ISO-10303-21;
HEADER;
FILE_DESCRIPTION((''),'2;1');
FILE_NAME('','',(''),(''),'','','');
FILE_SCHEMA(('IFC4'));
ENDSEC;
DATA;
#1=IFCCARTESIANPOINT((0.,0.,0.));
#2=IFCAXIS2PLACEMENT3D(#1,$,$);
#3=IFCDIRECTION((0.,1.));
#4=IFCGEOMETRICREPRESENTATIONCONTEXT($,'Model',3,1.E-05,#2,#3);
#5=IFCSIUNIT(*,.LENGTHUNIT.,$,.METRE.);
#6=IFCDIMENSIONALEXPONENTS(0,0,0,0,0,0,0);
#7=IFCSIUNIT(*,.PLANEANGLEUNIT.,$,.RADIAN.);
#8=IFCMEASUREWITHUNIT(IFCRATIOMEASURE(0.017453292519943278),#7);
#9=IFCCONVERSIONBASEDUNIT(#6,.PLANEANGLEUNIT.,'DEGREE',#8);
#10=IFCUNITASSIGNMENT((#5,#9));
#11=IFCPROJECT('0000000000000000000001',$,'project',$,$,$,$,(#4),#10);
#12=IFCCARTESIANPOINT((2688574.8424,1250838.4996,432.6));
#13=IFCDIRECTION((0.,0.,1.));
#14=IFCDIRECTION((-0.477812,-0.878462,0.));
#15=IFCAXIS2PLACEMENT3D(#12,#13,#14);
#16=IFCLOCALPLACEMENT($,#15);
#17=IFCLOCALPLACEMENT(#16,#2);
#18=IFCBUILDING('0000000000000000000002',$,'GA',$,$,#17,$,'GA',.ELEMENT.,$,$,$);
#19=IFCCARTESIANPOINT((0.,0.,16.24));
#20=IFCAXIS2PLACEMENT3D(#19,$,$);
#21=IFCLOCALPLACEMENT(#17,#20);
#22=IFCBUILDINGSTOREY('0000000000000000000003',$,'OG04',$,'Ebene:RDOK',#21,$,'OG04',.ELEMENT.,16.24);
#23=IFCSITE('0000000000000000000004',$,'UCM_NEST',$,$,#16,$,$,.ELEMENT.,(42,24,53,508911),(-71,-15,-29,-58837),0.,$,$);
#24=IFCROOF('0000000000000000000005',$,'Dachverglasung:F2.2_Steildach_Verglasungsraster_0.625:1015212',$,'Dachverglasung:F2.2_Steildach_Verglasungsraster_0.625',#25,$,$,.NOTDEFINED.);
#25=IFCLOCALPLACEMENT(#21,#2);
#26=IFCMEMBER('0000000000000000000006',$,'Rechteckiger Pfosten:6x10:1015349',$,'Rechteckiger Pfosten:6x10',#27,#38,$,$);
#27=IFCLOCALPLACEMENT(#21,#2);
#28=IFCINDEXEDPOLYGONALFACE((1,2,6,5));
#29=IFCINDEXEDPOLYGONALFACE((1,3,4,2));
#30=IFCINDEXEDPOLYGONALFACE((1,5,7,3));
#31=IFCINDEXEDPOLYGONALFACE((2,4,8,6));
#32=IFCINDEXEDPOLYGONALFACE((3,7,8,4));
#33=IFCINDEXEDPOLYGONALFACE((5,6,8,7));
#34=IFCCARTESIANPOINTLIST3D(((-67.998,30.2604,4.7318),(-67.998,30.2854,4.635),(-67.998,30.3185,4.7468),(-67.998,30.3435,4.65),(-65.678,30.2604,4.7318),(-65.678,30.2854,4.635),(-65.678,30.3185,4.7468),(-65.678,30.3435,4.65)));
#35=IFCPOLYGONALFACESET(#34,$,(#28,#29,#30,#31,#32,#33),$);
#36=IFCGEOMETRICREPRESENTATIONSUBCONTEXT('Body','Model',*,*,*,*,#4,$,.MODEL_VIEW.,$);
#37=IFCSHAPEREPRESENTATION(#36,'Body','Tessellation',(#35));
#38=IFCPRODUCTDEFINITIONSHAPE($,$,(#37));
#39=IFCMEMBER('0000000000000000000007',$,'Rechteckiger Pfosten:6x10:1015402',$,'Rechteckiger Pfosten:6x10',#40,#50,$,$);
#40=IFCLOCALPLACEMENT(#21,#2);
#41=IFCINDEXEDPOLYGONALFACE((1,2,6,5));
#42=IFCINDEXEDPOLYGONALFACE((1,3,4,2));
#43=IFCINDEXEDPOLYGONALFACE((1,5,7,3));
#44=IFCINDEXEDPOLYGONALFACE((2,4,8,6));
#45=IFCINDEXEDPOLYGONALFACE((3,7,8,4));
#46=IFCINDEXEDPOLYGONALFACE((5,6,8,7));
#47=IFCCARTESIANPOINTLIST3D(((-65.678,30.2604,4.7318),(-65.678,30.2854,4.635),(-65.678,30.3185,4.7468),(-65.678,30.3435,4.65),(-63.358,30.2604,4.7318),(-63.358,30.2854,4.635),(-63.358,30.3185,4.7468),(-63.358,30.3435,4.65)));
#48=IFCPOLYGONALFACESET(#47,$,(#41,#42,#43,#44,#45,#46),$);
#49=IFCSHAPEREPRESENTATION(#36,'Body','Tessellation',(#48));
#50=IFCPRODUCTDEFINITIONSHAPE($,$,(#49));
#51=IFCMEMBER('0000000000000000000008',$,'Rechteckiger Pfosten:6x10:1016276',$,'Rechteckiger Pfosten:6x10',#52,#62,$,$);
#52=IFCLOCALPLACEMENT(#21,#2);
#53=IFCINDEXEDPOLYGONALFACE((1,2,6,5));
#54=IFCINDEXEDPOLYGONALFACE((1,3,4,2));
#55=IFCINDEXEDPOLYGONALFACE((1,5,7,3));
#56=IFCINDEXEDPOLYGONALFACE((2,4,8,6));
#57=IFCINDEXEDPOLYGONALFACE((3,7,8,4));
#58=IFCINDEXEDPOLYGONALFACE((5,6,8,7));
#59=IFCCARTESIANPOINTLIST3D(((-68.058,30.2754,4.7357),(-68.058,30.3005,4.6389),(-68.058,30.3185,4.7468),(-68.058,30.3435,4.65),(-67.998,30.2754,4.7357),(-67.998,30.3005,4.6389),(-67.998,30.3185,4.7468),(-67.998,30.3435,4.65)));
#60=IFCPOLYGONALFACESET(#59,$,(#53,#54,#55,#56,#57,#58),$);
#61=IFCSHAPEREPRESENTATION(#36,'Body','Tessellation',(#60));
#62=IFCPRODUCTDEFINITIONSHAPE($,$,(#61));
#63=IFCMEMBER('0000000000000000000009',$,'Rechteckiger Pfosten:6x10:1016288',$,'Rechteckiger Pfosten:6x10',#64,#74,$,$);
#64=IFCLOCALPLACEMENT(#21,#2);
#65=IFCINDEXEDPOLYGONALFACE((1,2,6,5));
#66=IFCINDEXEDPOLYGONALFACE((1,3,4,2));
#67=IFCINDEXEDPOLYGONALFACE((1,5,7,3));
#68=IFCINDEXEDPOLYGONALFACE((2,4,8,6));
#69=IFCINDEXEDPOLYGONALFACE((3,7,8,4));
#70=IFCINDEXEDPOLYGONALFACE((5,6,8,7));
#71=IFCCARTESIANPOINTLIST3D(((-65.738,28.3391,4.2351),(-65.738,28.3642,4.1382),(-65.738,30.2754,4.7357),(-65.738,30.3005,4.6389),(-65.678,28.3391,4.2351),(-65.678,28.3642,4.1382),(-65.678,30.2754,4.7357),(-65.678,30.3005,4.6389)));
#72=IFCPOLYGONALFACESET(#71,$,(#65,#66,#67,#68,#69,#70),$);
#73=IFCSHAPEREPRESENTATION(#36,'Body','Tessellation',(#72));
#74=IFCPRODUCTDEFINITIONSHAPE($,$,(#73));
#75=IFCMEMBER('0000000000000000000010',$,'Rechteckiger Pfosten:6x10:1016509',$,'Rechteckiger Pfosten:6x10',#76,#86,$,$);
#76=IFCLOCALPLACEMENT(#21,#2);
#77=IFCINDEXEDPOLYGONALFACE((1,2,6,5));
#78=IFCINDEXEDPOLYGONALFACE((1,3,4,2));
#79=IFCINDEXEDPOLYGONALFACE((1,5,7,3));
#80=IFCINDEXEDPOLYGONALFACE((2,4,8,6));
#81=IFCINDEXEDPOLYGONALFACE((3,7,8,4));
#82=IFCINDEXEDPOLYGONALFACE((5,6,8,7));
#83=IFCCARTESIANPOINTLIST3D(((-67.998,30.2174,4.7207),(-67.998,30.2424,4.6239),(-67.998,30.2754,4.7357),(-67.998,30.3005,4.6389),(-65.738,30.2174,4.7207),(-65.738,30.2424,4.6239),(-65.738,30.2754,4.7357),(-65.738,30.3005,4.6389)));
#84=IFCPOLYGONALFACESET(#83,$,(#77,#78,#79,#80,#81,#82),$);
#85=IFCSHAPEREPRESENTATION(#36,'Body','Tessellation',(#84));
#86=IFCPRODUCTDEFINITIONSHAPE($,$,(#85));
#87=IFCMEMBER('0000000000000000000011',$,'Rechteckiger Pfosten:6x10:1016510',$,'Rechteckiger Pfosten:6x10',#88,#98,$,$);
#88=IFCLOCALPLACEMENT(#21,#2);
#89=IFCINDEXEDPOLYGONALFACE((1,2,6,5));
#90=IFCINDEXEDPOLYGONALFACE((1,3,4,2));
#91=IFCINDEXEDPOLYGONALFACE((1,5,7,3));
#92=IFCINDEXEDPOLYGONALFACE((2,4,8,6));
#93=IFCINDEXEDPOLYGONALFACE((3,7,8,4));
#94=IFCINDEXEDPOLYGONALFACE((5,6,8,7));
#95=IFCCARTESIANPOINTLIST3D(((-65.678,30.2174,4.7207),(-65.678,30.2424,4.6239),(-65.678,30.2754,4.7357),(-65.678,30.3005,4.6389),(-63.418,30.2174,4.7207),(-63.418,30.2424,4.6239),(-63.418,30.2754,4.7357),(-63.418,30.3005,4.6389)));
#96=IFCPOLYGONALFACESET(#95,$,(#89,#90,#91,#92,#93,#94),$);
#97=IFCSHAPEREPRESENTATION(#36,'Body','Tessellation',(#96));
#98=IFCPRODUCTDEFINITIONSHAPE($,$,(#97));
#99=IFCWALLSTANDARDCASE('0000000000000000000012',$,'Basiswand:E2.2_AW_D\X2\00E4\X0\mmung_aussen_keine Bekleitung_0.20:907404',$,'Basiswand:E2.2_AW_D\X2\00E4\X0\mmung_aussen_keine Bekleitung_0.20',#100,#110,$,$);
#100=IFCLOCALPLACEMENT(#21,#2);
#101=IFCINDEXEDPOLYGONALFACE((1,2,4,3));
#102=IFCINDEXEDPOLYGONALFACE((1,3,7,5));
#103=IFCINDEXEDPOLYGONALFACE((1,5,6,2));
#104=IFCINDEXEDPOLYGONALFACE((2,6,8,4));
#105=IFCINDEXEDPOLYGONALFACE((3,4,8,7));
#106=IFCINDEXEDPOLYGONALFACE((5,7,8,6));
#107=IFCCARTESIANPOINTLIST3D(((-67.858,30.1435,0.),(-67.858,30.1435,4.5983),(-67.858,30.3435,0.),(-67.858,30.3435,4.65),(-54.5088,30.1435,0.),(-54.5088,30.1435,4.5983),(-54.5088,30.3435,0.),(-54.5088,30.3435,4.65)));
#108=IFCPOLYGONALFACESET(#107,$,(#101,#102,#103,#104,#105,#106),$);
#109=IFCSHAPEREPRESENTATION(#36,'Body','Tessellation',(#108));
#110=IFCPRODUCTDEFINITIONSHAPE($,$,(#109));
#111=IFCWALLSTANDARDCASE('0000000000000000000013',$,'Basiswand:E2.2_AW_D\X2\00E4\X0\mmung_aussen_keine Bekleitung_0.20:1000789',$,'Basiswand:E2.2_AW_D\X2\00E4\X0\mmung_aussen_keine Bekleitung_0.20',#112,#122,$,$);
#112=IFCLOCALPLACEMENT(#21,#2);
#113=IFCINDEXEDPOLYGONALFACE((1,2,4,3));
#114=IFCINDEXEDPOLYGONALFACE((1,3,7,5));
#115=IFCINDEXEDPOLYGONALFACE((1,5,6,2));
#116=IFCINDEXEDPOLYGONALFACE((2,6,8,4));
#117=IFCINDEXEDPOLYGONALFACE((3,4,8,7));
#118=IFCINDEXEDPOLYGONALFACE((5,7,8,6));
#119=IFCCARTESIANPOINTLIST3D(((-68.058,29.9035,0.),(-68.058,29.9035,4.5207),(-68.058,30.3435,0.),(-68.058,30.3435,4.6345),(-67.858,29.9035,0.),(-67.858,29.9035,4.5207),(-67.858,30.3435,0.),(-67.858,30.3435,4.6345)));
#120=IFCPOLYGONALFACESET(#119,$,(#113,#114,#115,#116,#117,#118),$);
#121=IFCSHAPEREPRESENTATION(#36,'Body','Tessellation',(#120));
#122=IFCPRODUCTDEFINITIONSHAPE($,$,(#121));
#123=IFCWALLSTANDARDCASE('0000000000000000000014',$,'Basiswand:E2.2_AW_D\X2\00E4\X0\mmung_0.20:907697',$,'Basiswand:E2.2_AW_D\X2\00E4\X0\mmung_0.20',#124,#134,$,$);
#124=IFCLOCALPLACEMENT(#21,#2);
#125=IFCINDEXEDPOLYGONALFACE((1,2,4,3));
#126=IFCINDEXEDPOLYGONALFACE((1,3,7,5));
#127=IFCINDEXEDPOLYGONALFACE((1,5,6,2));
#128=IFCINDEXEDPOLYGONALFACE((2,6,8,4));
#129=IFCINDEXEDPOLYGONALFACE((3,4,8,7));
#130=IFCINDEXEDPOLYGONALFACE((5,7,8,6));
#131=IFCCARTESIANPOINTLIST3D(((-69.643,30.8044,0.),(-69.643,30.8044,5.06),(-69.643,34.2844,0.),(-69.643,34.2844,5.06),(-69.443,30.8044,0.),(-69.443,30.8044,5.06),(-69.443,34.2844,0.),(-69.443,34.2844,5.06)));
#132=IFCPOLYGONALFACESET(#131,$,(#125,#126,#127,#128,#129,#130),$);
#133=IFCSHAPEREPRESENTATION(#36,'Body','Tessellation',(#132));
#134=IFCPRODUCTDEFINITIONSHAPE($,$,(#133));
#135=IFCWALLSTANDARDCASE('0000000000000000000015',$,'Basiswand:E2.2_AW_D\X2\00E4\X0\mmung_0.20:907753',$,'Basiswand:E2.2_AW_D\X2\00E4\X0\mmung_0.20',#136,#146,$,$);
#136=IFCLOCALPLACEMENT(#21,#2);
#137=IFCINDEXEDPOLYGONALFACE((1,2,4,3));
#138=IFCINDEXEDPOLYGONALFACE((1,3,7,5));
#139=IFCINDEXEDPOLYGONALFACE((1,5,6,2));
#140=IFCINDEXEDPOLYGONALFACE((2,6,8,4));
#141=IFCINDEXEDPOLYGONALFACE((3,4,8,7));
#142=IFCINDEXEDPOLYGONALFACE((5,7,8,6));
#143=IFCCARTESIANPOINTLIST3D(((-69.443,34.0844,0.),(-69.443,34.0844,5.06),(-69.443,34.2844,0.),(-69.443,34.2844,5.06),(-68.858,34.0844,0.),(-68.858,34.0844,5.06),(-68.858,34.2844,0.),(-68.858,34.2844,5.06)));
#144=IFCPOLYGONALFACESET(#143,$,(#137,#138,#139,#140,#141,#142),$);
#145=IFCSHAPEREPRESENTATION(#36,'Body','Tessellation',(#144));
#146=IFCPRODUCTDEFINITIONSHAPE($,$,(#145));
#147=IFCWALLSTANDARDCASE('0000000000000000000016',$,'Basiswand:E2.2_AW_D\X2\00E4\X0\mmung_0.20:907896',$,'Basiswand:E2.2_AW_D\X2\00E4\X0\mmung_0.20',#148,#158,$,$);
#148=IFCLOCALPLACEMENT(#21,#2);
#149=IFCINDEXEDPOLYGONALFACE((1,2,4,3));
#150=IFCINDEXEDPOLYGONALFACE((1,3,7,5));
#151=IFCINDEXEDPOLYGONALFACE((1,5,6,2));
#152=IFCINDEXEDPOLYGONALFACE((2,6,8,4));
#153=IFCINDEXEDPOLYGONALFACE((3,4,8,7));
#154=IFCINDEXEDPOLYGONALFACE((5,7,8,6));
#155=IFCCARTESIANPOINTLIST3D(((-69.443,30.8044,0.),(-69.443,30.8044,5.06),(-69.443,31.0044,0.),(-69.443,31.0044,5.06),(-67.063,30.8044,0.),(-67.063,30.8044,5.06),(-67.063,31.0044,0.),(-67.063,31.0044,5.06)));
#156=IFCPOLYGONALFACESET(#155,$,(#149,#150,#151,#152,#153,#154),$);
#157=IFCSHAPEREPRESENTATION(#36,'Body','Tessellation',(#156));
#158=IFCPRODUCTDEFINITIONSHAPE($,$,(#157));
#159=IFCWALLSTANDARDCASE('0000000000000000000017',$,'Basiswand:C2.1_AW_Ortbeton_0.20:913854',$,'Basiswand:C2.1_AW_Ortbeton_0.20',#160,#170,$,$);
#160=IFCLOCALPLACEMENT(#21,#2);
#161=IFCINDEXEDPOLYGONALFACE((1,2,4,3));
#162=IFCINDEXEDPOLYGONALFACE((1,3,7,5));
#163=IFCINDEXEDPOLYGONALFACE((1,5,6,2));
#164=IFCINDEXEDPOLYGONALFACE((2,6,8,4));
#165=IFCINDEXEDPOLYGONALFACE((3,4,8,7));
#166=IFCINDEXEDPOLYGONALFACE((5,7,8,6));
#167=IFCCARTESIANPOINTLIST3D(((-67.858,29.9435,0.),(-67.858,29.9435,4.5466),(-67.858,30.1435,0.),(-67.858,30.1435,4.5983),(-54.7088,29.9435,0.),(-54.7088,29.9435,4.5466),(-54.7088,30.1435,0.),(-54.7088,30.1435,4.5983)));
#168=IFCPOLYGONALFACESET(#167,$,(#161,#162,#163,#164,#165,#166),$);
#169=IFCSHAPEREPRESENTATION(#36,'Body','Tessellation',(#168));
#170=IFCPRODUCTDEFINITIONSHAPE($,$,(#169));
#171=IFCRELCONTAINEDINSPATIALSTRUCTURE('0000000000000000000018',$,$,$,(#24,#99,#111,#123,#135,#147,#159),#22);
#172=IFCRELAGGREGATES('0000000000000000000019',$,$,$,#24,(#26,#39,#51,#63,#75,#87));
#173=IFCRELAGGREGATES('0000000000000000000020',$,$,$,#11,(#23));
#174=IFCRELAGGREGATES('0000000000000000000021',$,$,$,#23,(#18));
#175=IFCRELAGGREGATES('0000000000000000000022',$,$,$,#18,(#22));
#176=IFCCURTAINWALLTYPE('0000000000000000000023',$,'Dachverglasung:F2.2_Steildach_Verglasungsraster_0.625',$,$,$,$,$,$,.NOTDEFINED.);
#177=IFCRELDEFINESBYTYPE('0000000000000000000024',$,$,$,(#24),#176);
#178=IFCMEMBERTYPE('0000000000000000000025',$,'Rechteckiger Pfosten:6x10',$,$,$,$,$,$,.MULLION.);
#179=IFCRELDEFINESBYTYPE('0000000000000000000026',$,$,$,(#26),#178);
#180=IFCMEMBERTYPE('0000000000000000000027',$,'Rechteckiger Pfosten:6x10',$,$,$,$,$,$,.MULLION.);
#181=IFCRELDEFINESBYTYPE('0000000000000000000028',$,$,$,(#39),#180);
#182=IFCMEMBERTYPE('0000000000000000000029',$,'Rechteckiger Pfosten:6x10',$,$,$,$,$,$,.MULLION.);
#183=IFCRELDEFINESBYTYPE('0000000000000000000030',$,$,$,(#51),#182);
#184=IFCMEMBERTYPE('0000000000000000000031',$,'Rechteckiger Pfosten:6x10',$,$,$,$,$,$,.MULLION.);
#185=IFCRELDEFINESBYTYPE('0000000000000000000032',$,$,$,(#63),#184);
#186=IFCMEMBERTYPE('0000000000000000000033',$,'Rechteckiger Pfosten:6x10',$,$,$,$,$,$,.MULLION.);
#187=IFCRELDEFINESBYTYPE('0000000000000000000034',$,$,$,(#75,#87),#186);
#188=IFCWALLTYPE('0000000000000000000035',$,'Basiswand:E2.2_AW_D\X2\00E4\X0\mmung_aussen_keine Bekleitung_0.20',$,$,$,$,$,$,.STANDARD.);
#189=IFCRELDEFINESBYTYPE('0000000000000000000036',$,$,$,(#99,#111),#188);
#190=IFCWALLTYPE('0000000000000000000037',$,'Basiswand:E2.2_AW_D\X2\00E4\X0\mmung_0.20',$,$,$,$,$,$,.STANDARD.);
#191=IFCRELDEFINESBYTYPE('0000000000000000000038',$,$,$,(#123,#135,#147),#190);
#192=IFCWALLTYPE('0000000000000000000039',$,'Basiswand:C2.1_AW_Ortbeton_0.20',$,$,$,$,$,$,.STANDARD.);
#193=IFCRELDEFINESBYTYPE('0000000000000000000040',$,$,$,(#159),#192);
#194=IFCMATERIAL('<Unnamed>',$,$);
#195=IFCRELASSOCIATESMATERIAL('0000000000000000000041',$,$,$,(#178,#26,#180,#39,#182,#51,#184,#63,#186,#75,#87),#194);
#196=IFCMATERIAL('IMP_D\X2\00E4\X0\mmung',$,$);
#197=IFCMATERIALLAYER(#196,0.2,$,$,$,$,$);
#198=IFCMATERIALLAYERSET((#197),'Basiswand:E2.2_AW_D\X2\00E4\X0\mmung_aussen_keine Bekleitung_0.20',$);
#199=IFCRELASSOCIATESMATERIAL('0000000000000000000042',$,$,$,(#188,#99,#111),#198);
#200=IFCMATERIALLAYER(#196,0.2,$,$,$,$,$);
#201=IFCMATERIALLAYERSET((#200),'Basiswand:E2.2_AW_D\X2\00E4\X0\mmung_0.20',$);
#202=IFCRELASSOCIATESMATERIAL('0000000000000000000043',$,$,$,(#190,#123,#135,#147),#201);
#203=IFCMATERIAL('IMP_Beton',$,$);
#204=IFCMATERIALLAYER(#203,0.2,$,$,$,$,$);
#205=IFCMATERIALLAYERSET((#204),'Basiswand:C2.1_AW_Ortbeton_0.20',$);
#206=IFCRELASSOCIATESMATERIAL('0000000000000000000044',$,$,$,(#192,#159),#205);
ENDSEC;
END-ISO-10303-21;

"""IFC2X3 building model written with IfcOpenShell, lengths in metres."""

from ifc_helpers import new_model, entity, si_unit, converted_unit, direction, frame, frame_2d, origin, origin_2d_with_axis, place, context, subcontext, project, spatial, polyline, rectangle, extrude, clip, halfspace, bounded_halfspace, source, transform, mapped, material, layer, layer_set, layer_usage, type_object, type_shapes, element, aggregate, save


model = new_model("IFC2X3")

# Units and contexts
model_context = context("Model", 3, precision=1e-05, world=origin(), true_north=direction((0.0, 1.0)))
body_context = subcontext(model_context, "Body", "Model", "MODEL_VIEW")
ifc_project = project(units=[si_unit("LENGTHUNIT", "METRE"), converted_unit("PLANEANGLEUNIT", "DEGREE", entity("IfcRatioMeasure", 0.017453292519943278), si_unit("PLANEANGLEUNIT", "RADIAN"), dimensions=[0, 0, 0, 0, 0, 0, 0])], contexts=[model_context])

# Site, building, storey
site_placement = place(None, frame((2688574.8424, 1250838.4996, 432.6), z_axis=(0.0, 0.0, 1.0), x_axis=(-0.477812, -0.878462, 0.0)))
site = spatial("IfcSite", under=ifc_project, at=site_placement, Name="UCM_NEST", CompositionType="ELEMENT", RefLatitude=(42, 24, 53, 508911), RefLongitude=(-71, -15, -29, -58837), RefElevation=0.0)
building_placement = place(site_placement, origin())
building = spatial("IfcBuilding", under=site, at=building_placement, Name="GA", LongName="GA", CompositionType="ELEMENT")
storey_placement = place(building_placement, frame((0.0, 0.0, 16.24)))
storey = spatial("IfcBuildingStorey", under=building, at=storey_placement, Name="OG04", ObjectType="Ebene:RDOK", LongName="OG04", CompositionType="ELEMENT", Elevation=16.24)

# Roof, members
curtain_wall_type = type_object("IfcCurtainWallType", Name="Dachverglasung:F2.2_Steildach_Verglasungsraster_0.625", PredefinedType="NOTDEFINED")
roof_placement = place(storey_placement, frame((0.0, 0.0, -16.24)))
roof = element("IfcRoof", 1, at=roof_placement, inside=storey, type_object=curtain_wall_type, Name="Dachverglasung:F2.2_Steildach_Verglasungsraster_0.625:1015212", ObjectType="Dachverglasung:F2.2_Steildach_Verglasungsraster_0.625", ShapeType="NOTDEFINED")
ifc_material_1 = material(Name="<Unnamed>")
member_type_1 = type_object("IfcMemberType", Name="Rechteckiger Pfosten:6x10", PredefinedType="MULLION", material=ifc_material_1)
shared_shape_1 = source(origin(), body_context, "Body", "SweptSolid", [
    extrude(rectangle(XDim=0.1, YDim=0.06, at=origin_2d_with_axis()), frame((-0.03, -0.05, -2.32), z_axis=(0.0, 0.0, 1.0), x_axis=(0.0, -1.0, 0.0)), (0.0, 0.0, 1.0), 2.32),
])
type_shapes(member_type_1, [shared_shape_1])
member_1_placement = place(roof_placement, frame((-67.998, 30.3435, 20.89), z_axis=(-1.0, 0.0, 0.0), x_axis=(0.0, 0.968163, 0.250322)))
member_1 = element("IfcMember", 2, at=member_1_placement, type_object=member_type_1, material=ifc_material_1, Name="Rechteckiger Pfosten:6x10:1015349", ObjectType="Rechteckiger Pfosten:6x10", context=body_context, shape_type="MappedRepresentation", body=[
    mapped(shared_shape_1, transform((0.0, 0.0, 0.0), scale=1.0)),
])
member_type_2 = type_object("IfcMemberType", Name="Rechteckiger Pfosten:6x10", PredefinedType="MULLION", material=ifc_material_1)
shared_shape_2 = source(origin(), body_context, "Body", "SweptSolid", [
    extrude(rectangle(XDim=0.1, YDim=0.06, at=origin_2d_with_axis()), frame((-0.03, -0.05, -2.32), z_axis=(0.0, 0.0, 1.0), x_axis=(0.0, -1.0, 0.0)), (0.0, 0.0, 1.0), 2.32),
])
type_shapes(member_type_2, [shared_shape_2])
member_2_placement = place(roof_placement, frame((-65.678, 30.3435, 20.89), z_axis=(-1.0, 0.0, 0.0), x_axis=(0.0, 0.968163, 0.250322)))
member_2 = element("IfcMember", 3, at=member_2_placement, type_object=member_type_2, material=ifc_material_1, Name="Rechteckiger Pfosten:6x10:1015402", ObjectType="Rechteckiger Pfosten:6x10", context=body_context, shape_type="MappedRepresentation", body=[
    mapped(shared_shape_2, transform((0.0, 0.0, 0.0), scale=1.0)),
])
member_type_3 = type_object("IfcMemberType", Name="Rechteckiger Pfosten:6x10", PredefinedType="MULLION", material=ifc_material_1)
shared_shape_3 = source(origin(), body_context, "Body", "SweptSolid", [
    extrude(rectangle(XDim=0.1, YDim=0.06, at=origin_2d_with_axis()), frame((-0.03, -0.05, -0.0444), z_axis=(0.0, 0.0, 1.0), x_axis=(0.0, -1.0, 0.0)), (0.0, 0.0, 1.0), 0.0444),
])
type_shapes(member_type_3, [shared_shape_3])
member_3_placement = place(roof_placement, frame((-68.058, 30.3005, 20.8789), z_axis=(0.0, -0.968163, -0.250322), x_axis=(-1.0, 0.0, 0.0)))
member_3 = element("IfcMember", 4, at=member_3_placement, type_object=member_type_3, material=ifc_material_1, Name="Rechteckiger Pfosten:6x10:1016276", ObjectType="Rechteckiger Pfosten:6x10", context=body_context, shape_type="MappedRepresentation", body=[
    mapped(shared_shape_3, transform((0.0, 0.0, 0.0), scale=1.0)),
])
member_type_4 = type_object("IfcMemberType", Name="Rechteckiger Pfosten:6x10", PredefinedType="MULLION", material=ifc_material_1)
shared_shape_4 = source(origin(), body_context, "Body", "SweptSolid", [
    extrude(rectangle(XDim=0.1, YDim=0.06, at=origin_2d_with_axis()), frame((-0.03, -0.05, -2.0), z_axis=(0.0, 0.0, 1.0), x_axis=(0.0, -1.0, 0.0)), (0.0, 0.0, 1.0), 2.0),
])
type_shapes(member_type_4, [shared_shape_4])
member_4_placement = place(roof_placement, frame((-65.678, 30.3005, 20.8789), z_axis=(0.0, 0.968163, 0.250322), x_axis=(1.0, 0.0, 0.0)))
member_4 = element("IfcMember", 5, at=member_4_placement, type_object=member_type_4, material=ifc_material_1, Name="Rechteckiger Pfosten:6x10:1016288", ObjectType="Rechteckiger Pfosten:6x10", context=body_context, shape_type="MappedRepresentation", body=[
    mapped(shared_shape_4, transform((0.0, 0.0, 0.0), scale=1.0)),
])
member_type_5 = type_object("IfcMemberType", Name="Rechteckiger Pfosten:6x10", PredefinedType="MULLION", material=ifc_material_1)
shared_shape_5 = source(origin(), body_context, "Body", "SweptSolid", [
    extrude(rectangle(XDim=0.1, YDim=0.06, at=origin_2d_with_axis()), frame((-0.03, -0.05, -2.26), z_axis=(0.0, 0.0, 1.0), x_axis=(0.0, -1.0, 0.0)), (0.0, 0.0, 1.0), 2.26),
])
type_shapes(member_type_5, [shared_shape_5])
member_5_placement = place(roof_placement, frame((-67.998, 30.3005, 20.8789), z_axis=(-1.0, 0.0, 0.0), x_axis=(0.0, 0.968163, 0.250322)))
member_5 = element("IfcMember", 6, at=member_5_placement, type_object=member_type_5, material=ifc_material_1, Name="Rechteckiger Pfosten:6x10:1016509", ObjectType="Rechteckiger Pfosten:6x10", context=body_context, shape_type="MappedRepresentation", body=[
    mapped(shared_shape_5, transform((0.0, 0.0, 0.0), scale=1.0)),
])
member_6_placement = place(roof_placement, frame((-65.678, 30.3005, 20.8789), z_axis=(-1.0, 0.0, 0.0), x_axis=(0.0, 0.968163, 0.250322)))
member_6 = element("IfcMember", 7, at=member_6_placement, type_object=member_type_5, material=ifc_material_1, Name="Rechteckiger Pfosten:6x10:1016510", ObjectType="Rechteckiger Pfosten:6x10", context=body_context, shape_type="MappedRepresentation", body=[
    mapped(shared_shape_5, transform((0.0, 0.0, 0.0), scale=1.0)),
])
aggregate(roof, [member_1, member_2, member_3, member_4, member_5, member_6])

# Walls
ifc_material_2 = material(Name="IMP_Dämmung")
ifc_layer_1 = layer(ifc_material_2, 0.2)
ifc_layer_set_1 = layer_set([ifc_layer_1], Name="Basiswand:E2.2_AW_Dämmung_aussen_keine Bekleitung_0.20")
ifc_layer_usage_1 = layer_usage(ifc_layer_set_1, "AXIS2", "NEGATIVE", 0.1)
wall_type_1 = type_object("IfcWallType", Name="Basiswand:E2.2_AW_Dämmung_aussen_keine Bekleitung_0.20", PredefinedType="STANDARD", material=ifc_layer_set_1)
wall_1_placement = place(storey_placement, frame((-67.858, 30.2435, 0.0)))
element("IfcWallStandardCase", 8, at=wall_1_placement, inside=storey, type_object=wall_type_1, material=ifc_layer_usage_1, Name="Basiswand:E2.2_AW_Dämmung_aussen_keine Bekleitung_0.20:907404", ObjectType="Basiswand:E2.2_AW_Dämmung_aussen_keine Bekleitung_0.20", context=body_context, shape_type="Clipping", body=[
    clip(extrude(rectangle(XDim=13.3492, YDim=0.2, at=frame_2d((6.6746, 0.0), x_axis=(-1.0, 0.0))), origin(), (0.0, 0.0, 1.0), 4.65), bounded_halfspace(frame((0.0, -0.1, 4.5983), z_axis=(0.0, -0.250322, 0.968163), x_axis=(1.0, 0.0, 0.0)), False, frame((0.0, -0.1, 4.5983)), polyline([(0.0, 0.0), (13.3492, 0.0), (13.3492, 0.2), (0.0, 0.2), (0.0, 0.0)]))),
])
wall_2_placement = place(storey_placement, frame((-67.958, 30.3435, 0.0), z_axis=(0.0, 0.0, 1.0), x_axis=(0.0, -1.0, 0.0)))
element("IfcWallStandardCase", 9, at=wall_2_placement, inside=storey, type_object=wall_type_1, material=ifc_layer_usage_1, Name="Basiswand:E2.2_AW_Dämmung_aussen_keine Bekleitung_0.20:1000789", ObjectType="Basiswand:E2.2_AW_Dämmung_aussen_keine Bekleitung_0.20", context=body_context, shape_type="Clipping", body=[
    clip(extrude(rectangle(XDim=0.44, YDim=0.2, at=frame_2d((0.22, 0.0), x_axis=(-1.0, 0.0))), origin(), (0.0, 0.0, 1.0), 4.6345), halfspace(frame((0.0, -0.1, 4.6345), z_axis=(0.250322, 0.0, 0.968163), x_axis=(0.0, 1.0, 0.0)), False)),
])
ifc_layer_2 = layer(ifc_material_2, 0.2)
ifc_layer_set_2 = layer_set([ifc_layer_2], Name="Basiswand:E2.2_AW_Dämmung_0.20")
ifc_layer_usage_2 = layer_usage(ifc_layer_set_2, "AXIS2", "NEGATIVE", 0.1)
wall_type_2 = type_object("IfcWallType", Name="Basiswand:E2.2_AW_Dämmung_0.20", PredefinedType="STANDARD", material=ifc_layer_set_2)
wall_3_placement = place(storey_placement, frame((-69.543, 30.8044, 0.0), z_axis=(0.0, 0.0, 1.0), x_axis=(0.0, 1.0, 0.0)))
element("IfcWallStandardCase", 10, at=wall_3_placement, inside=storey, type_object=wall_type_2, material=ifc_layer_usage_2, Name="Basiswand:E2.2_AW_Dämmung_0.20:907697", ObjectType="Basiswand:E2.2_AW_Dämmung_0.20", context=body_context, shape_type="SweptSolid", body=[
    extrude(rectangle(XDim=3.48, YDim=0.2, at=frame_2d((1.74, 0.0), x_axis=(-1.0, 0.0))), origin(), (0.0, 0.0, 1.0), 5.06),
])
wall_4_placement = place(storey_placement, frame((-69.443, 34.1844, 0.0)))
element("IfcWallStandardCase", 11, at=wall_4_placement, inside=storey, type_object=wall_type_2, material=ifc_layer_usage_2, Name="Basiswand:E2.2_AW_Dämmung_0.20:907753", ObjectType="Basiswand:E2.2_AW_Dämmung_0.20", context=body_context, shape_type="SweptSolid", body=[
    extrude(rectangle(XDim=0.585, YDim=0.2, at=frame_2d((0.2925, 0.0), x_axis=(-1.0, 0.0))), origin(), (0.0, 0.0, 1.0), 5.06),
])
wall_5_placement = place(storey_placement, frame((-67.063, 30.9044, 0.0), z_axis=(0.0, 0.0, 1.0), x_axis=(-1.0, 0.0, 0.0)))
element("IfcWallStandardCase", 12, at=wall_5_placement, inside=storey, type_object=wall_type_2, material=ifc_layer_usage_2, Name="Basiswand:E2.2_AW_Dämmung_0.20:907896", ObjectType="Basiswand:E2.2_AW_Dämmung_0.20", context=body_context, shape_type="SweptSolid", body=[
    extrude(rectangle(XDim=2.38, YDim=0.2, at=frame_2d((1.19, 0.0), x_axis=(-1.0, 0.0))), origin(), (0.0, 0.0, 1.0), 5.06),
])

# Shared definitions
ifc_material_3 = material(Name="IMP_Beton")

# Wall
ifc_layer_3 = layer(ifc_material_3, 0.2)
ifc_layer_set_3 = layer_set([ifc_layer_3], Name="Basiswand:C2.1_AW_Ortbeton_0.20")
ifc_layer_usage_3 = layer_usage(ifc_layer_set_3, "AXIS2", "NEGATIVE", 0.1)
wall_type_3 = type_object("IfcWallType", Name="Basiswand:C2.1_AW_Ortbeton_0.20", PredefinedType="STANDARD", material=ifc_layer_set_3)
wall_6_placement = place(storey_placement, frame((-67.858, 30.0435, 0.0)))
element("IfcWallStandardCase", 13, at=wall_6_placement, inside=storey, type_object=wall_type_3, material=ifc_layer_usage_3, Name="Basiswand:C2.1_AW_Ortbeton_0.20:913854", ObjectType="Basiswand:C2.1_AW_Ortbeton_0.20", context=body_context, shape_type="Clipping", body=[
    clip(extrude(rectangle(XDim=13.1492, YDim=0.2, at=frame_2d((6.5746, 0.0), x_axis=(-1.0, 0.0))), origin(), (0.0, 0.0, 1.0), 4.5983), bounded_halfspace(frame((0.0, -0.1, 4.5466), z_axis=(0.0, -0.250322, 0.968163), x_axis=(1.0, 0.0, 0.0)), False, frame((0.0, -0.1, 4.5466)), polyline([(0.0, 0.0), (13.1492, 0.0), (13.1492, 0.2), (0.0, 0.2), (0.0, 0.0)]))),
])

save(model, "model.ifc")
